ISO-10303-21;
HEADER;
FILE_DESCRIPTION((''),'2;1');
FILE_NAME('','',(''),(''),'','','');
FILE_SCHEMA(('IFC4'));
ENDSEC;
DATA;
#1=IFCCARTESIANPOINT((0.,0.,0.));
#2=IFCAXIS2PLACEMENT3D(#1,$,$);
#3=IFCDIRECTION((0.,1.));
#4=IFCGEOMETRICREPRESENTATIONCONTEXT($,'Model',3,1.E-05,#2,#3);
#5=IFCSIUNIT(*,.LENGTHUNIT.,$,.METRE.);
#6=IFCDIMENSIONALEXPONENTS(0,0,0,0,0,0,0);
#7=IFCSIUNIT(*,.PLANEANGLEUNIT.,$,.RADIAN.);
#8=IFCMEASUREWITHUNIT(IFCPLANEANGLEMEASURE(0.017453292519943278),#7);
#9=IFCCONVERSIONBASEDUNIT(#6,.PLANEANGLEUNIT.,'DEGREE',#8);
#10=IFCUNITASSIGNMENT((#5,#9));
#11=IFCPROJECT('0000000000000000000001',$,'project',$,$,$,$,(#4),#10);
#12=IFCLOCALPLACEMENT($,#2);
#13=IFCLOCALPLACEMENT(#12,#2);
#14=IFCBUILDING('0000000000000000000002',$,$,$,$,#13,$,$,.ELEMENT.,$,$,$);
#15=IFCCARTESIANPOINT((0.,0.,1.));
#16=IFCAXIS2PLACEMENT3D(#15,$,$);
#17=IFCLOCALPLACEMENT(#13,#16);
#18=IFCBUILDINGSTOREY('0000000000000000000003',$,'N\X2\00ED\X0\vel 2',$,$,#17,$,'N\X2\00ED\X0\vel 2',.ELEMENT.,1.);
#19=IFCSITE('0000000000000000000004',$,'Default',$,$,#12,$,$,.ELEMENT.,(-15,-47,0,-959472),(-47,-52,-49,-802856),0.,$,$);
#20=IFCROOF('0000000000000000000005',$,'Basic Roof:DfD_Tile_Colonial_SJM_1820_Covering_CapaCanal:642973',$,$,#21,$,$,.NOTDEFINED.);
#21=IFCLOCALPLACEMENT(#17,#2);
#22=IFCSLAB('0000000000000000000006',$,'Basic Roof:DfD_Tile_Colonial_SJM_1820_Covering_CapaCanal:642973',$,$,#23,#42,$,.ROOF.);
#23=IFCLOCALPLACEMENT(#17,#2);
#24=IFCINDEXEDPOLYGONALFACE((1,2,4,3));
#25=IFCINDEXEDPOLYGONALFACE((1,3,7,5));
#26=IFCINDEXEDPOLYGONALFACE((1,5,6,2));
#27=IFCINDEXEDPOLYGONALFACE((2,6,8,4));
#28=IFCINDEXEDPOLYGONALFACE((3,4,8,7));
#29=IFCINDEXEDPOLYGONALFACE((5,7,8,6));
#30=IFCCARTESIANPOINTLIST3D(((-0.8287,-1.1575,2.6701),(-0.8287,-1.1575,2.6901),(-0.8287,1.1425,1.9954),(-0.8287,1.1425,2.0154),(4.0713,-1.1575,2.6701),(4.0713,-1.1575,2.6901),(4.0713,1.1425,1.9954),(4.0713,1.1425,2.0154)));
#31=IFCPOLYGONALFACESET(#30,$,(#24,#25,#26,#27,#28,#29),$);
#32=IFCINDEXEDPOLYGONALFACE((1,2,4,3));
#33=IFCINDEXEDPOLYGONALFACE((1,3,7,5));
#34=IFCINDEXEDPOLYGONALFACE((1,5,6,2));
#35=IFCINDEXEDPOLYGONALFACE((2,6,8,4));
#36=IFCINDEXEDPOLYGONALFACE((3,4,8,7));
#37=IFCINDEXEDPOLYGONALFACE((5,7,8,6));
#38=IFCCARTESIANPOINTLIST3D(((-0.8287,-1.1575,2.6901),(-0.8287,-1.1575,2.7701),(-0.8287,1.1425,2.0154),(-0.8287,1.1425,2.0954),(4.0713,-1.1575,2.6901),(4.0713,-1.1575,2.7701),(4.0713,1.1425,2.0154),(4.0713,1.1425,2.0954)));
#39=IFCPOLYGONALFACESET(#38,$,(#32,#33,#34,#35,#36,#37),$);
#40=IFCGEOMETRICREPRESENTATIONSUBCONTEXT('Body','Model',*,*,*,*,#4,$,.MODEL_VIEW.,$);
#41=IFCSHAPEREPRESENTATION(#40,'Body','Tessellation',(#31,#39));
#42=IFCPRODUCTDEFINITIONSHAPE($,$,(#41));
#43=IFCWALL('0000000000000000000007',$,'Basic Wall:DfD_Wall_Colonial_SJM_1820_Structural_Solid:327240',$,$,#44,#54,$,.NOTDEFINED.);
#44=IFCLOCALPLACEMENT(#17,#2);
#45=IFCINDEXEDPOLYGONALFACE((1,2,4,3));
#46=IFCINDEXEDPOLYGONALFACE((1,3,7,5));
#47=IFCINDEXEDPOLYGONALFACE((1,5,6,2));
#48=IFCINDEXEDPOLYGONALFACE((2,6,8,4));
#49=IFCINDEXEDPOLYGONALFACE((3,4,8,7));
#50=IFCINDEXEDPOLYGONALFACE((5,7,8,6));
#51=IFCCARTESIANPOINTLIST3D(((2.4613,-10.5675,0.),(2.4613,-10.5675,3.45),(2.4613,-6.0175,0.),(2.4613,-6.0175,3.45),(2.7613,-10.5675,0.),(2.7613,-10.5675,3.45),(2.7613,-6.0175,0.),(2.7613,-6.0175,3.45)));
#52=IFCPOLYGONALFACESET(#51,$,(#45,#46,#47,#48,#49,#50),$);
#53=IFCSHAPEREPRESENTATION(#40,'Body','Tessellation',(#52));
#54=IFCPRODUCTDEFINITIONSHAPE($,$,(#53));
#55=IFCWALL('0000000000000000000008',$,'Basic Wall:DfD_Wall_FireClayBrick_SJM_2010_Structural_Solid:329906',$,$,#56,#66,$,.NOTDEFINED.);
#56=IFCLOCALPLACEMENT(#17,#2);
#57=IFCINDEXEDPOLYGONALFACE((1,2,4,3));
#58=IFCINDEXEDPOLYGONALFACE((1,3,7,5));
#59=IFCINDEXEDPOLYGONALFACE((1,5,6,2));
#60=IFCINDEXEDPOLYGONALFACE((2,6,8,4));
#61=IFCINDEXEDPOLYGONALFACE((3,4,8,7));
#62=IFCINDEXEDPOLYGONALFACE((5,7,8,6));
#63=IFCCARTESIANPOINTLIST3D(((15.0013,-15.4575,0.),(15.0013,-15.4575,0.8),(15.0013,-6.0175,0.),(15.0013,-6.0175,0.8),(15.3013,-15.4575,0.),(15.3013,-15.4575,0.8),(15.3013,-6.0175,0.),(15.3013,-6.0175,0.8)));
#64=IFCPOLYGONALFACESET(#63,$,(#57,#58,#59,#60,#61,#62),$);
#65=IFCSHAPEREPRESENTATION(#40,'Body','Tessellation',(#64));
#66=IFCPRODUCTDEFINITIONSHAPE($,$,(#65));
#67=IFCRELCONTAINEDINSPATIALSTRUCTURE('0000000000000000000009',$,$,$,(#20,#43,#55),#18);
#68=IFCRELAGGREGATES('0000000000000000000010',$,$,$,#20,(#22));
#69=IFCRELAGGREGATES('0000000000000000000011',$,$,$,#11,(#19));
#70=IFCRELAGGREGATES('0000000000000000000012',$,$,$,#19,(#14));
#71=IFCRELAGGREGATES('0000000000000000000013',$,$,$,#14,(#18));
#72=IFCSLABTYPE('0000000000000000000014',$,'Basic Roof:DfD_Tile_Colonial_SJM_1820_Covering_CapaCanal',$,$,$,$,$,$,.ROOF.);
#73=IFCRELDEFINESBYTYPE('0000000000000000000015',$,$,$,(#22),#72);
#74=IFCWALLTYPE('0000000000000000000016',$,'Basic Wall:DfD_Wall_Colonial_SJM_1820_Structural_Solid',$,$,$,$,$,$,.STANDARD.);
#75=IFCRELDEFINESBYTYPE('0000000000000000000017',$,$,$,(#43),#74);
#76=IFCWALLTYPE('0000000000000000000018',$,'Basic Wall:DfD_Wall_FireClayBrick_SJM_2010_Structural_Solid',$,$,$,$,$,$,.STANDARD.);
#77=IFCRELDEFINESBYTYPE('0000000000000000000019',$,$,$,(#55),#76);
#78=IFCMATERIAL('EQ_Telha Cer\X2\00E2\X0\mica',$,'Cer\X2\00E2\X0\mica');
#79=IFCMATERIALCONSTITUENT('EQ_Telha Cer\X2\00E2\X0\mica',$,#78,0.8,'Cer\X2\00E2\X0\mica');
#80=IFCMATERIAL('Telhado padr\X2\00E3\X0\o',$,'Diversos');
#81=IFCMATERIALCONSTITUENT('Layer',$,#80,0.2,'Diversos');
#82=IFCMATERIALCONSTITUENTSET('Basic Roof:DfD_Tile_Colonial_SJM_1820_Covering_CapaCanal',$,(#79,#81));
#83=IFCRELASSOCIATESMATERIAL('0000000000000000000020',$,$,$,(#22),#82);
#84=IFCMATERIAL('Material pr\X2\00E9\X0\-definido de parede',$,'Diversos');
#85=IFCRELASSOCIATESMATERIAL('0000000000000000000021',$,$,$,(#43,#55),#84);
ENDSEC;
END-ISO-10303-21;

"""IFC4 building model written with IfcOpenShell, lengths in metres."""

from ifc_helpers import new_model, entity, si_unit, converted_unit, direction, frame, origin, place, context, subcontext, project, spatial, indexed_curve, outline, extrude, material, constituent, constituent_set, type_object, element, aggregate, save


model = new_model("IFC4")

# Units and contexts
model_context = context("Model", 3, precision=1e-05, world=origin(), true_north=direction((0.0, 1.0)))
body_context = subcontext(model_context, "Body", "Model", "MODEL_VIEW")
ifc_project = project(units=[si_unit("LENGTHUNIT", "METRE"), converted_unit("PLANEANGLEUNIT", "DEGREE", entity("IfcPlaneAngleMeasure", 0.017453292519943278), si_unit("PLANEANGLEUNIT", "RADIAN"), dimensions=[0, 0, 0, 0, 0, 0, 0])], contexts=[model_context])

# Site, building, storey
site_placement = place(None, origin())
site = spatial("IfcSite", under=ifc_project, at=site_placement, Name="Default", CompositionType="ELEMENT", RefLatitude=(-15, -47, 0, -959472), RefLongitude=(-47, -52, -49, -802856), RefElevation=0.0)
building_placement = place(site_placement, origin())
building = spatial("IfcBuilding", under=site, at=building_placement, CompositionType="ELEMENT")
storey_placement = place(building_placement, frame((0.0, 0.0, 1.0)))
storey = spatial("IfcBuildingStorey", under=building, at=storey_placement, Name="Nível 2", LongName="Nível 2", CompositionType="ELEMENT", Elevation=1.0)

# Roof, slab
roof_1_placement = place(storey_placement, frame((-0.8287, -1.1575, 1.9954)))
roof_1 = element("IfcRoof", 1, at=roof_1_placement, inside=storey, Name="Basic Roof:DfD_Tile_Colonial_SJM_1820_Covering_CapaCanal:642973", PredefinedType="NOTDEFINED")
ifc_material_1 = material(Name="EQ_Telha Cerâmica", Category="Cerâmica")
ifc_constituent_1 = constituent(ifc_material_1, Name="EQ_Telha Cerâmica", Category="Cerâmica", fraction=0.8)
ifc_material_2 = material(Name="Telhado padrão", Category="Diversos")
ifc_constituent_2 = constituent(ifc_material_2, Name="Layer", Category="Diversos", fraction=0.2)
ifc_constituent_set = constituent_set(constituents=[ifc_constituent_1, ifc_constituent_2], Name="Basic Roof:DfD_Tile_Colonial_SJM_1820_Covering_CapaCanal")
slab_type = type_object("IfcSlabType", Name="Basic Roof:DfD_Tile_Colonial_SJM_1820_Covering_CapaCanal", PredefinedType="ROOF")
slab_placement = place(roof_1_placement, origin())
slab = element("IfcSlab", 2, at=slab_placement, type_object=slab_type, material=ifc_constituent_set, Name="Basic Roof:DfD_Tile_Colonial_SJM_1820_Covering_CapaCanal:642973", PredefinedType="ROOF", context=body_context, shape_type="SweptSolid", body=[
    extrude(outline(indexed_curve([(-2.45, -1.1985), (2.45, -1.1985), (2.45, 1.1985), (-2.45, 1.1985), (-2.45, -1.1985)], self_intersect=False)), frame((2.45, 1.15, 0.3374), z_axis=(0.0, 0.281504, 0.95956), x_axis=(1.0, 0.0, 0.0)), (0.0, -0.281504, 0.95956), 0.02),
    extrude(outline(indexed_curve([(-2.45, -1.1985), (2.45, -1.1985), (2.45, 1.1985), (-2.45, 1.1985), (-2.45, -1.1985)], self_intersect=False)), frame((2.45, 1.15, 0.3574), z_axis=(0.0, 0.281504, 0.95956), x_axis=(1.0, 0.0, 0.0)), (0.0, -0.281504, 0.95956), 0.08),
])
aggregate(roof_1, [slab])

# Shared definitions
ifc_material_3 = material(Name="Material pré-definido de parede", Category="Diversos")
wall_type_1 = type_object("IfcWallType", Name="Basic Wall:DfD_Wall_Colonial_SJM_1820_Structural_Solid", PredefinedType="STANDARD")

# Walls
wall_1_placement = place(storey_placement, frame((2.6113, -10.5675, 0.0), z_axis=(0.0, 0.0, 1.0), x_axis=(0.0, 1.0, 0.0)))
element("IfcWall", 3, at=wall_1_placement, inside=storey, type_object=wall_type_1, material=ifc_material_3, Name="Basic Wall:DfD_Wall_Colonial_SJM_1820_Structural_Solid:327240", PredefinedType="NOTDEFINED", context=body_context, shape_type="SweptSolid", body=[
    extrude(outline(indexed_curve([(4.55, 0.15), (0.0, 0.15), (0.0, -0.15), (4.55, -0.15), (4.55, 0.15)], self_intersect=False)), origin(), (0.0, 0.0, 1.0), 3.45),
])
wall_type_2 = type_object("IfcWallType", Name="Basic Wall:DfD_Wall_FireClayBrick_SJM_2010_Structural_Solid", PredefinedType="STANDARD")
wall_2_placement = place(storey_placement, frame((15.1513, -15.4575, 0.0), z_axis=(0.0, 0.0, 1.0), x_axis=(0.0, 1.0, 0.0)))
element("IfcWall", 4, at=wall_2_placement, inside=storey, type_object=wall_type_2, material=ifc_material_3, Name="Basic Wall:DfD_Wall_FireClayBrick_SJM_2010_Structural_Solid:329906", PredefinedType="NOTDEFINED", context=body_context, shape_type="SweptSolid", body=[
    extrude(outline(indexed_curve([(9.44, 0.15), (0.0, 0.15), (0.0, -0.15), (9.44, -0.15), (9.44, 0.15)], self_intersect=False)), origin(), (0.0, 0.0, 1.0), 0.8),
])

save(model, "model.ifc")
